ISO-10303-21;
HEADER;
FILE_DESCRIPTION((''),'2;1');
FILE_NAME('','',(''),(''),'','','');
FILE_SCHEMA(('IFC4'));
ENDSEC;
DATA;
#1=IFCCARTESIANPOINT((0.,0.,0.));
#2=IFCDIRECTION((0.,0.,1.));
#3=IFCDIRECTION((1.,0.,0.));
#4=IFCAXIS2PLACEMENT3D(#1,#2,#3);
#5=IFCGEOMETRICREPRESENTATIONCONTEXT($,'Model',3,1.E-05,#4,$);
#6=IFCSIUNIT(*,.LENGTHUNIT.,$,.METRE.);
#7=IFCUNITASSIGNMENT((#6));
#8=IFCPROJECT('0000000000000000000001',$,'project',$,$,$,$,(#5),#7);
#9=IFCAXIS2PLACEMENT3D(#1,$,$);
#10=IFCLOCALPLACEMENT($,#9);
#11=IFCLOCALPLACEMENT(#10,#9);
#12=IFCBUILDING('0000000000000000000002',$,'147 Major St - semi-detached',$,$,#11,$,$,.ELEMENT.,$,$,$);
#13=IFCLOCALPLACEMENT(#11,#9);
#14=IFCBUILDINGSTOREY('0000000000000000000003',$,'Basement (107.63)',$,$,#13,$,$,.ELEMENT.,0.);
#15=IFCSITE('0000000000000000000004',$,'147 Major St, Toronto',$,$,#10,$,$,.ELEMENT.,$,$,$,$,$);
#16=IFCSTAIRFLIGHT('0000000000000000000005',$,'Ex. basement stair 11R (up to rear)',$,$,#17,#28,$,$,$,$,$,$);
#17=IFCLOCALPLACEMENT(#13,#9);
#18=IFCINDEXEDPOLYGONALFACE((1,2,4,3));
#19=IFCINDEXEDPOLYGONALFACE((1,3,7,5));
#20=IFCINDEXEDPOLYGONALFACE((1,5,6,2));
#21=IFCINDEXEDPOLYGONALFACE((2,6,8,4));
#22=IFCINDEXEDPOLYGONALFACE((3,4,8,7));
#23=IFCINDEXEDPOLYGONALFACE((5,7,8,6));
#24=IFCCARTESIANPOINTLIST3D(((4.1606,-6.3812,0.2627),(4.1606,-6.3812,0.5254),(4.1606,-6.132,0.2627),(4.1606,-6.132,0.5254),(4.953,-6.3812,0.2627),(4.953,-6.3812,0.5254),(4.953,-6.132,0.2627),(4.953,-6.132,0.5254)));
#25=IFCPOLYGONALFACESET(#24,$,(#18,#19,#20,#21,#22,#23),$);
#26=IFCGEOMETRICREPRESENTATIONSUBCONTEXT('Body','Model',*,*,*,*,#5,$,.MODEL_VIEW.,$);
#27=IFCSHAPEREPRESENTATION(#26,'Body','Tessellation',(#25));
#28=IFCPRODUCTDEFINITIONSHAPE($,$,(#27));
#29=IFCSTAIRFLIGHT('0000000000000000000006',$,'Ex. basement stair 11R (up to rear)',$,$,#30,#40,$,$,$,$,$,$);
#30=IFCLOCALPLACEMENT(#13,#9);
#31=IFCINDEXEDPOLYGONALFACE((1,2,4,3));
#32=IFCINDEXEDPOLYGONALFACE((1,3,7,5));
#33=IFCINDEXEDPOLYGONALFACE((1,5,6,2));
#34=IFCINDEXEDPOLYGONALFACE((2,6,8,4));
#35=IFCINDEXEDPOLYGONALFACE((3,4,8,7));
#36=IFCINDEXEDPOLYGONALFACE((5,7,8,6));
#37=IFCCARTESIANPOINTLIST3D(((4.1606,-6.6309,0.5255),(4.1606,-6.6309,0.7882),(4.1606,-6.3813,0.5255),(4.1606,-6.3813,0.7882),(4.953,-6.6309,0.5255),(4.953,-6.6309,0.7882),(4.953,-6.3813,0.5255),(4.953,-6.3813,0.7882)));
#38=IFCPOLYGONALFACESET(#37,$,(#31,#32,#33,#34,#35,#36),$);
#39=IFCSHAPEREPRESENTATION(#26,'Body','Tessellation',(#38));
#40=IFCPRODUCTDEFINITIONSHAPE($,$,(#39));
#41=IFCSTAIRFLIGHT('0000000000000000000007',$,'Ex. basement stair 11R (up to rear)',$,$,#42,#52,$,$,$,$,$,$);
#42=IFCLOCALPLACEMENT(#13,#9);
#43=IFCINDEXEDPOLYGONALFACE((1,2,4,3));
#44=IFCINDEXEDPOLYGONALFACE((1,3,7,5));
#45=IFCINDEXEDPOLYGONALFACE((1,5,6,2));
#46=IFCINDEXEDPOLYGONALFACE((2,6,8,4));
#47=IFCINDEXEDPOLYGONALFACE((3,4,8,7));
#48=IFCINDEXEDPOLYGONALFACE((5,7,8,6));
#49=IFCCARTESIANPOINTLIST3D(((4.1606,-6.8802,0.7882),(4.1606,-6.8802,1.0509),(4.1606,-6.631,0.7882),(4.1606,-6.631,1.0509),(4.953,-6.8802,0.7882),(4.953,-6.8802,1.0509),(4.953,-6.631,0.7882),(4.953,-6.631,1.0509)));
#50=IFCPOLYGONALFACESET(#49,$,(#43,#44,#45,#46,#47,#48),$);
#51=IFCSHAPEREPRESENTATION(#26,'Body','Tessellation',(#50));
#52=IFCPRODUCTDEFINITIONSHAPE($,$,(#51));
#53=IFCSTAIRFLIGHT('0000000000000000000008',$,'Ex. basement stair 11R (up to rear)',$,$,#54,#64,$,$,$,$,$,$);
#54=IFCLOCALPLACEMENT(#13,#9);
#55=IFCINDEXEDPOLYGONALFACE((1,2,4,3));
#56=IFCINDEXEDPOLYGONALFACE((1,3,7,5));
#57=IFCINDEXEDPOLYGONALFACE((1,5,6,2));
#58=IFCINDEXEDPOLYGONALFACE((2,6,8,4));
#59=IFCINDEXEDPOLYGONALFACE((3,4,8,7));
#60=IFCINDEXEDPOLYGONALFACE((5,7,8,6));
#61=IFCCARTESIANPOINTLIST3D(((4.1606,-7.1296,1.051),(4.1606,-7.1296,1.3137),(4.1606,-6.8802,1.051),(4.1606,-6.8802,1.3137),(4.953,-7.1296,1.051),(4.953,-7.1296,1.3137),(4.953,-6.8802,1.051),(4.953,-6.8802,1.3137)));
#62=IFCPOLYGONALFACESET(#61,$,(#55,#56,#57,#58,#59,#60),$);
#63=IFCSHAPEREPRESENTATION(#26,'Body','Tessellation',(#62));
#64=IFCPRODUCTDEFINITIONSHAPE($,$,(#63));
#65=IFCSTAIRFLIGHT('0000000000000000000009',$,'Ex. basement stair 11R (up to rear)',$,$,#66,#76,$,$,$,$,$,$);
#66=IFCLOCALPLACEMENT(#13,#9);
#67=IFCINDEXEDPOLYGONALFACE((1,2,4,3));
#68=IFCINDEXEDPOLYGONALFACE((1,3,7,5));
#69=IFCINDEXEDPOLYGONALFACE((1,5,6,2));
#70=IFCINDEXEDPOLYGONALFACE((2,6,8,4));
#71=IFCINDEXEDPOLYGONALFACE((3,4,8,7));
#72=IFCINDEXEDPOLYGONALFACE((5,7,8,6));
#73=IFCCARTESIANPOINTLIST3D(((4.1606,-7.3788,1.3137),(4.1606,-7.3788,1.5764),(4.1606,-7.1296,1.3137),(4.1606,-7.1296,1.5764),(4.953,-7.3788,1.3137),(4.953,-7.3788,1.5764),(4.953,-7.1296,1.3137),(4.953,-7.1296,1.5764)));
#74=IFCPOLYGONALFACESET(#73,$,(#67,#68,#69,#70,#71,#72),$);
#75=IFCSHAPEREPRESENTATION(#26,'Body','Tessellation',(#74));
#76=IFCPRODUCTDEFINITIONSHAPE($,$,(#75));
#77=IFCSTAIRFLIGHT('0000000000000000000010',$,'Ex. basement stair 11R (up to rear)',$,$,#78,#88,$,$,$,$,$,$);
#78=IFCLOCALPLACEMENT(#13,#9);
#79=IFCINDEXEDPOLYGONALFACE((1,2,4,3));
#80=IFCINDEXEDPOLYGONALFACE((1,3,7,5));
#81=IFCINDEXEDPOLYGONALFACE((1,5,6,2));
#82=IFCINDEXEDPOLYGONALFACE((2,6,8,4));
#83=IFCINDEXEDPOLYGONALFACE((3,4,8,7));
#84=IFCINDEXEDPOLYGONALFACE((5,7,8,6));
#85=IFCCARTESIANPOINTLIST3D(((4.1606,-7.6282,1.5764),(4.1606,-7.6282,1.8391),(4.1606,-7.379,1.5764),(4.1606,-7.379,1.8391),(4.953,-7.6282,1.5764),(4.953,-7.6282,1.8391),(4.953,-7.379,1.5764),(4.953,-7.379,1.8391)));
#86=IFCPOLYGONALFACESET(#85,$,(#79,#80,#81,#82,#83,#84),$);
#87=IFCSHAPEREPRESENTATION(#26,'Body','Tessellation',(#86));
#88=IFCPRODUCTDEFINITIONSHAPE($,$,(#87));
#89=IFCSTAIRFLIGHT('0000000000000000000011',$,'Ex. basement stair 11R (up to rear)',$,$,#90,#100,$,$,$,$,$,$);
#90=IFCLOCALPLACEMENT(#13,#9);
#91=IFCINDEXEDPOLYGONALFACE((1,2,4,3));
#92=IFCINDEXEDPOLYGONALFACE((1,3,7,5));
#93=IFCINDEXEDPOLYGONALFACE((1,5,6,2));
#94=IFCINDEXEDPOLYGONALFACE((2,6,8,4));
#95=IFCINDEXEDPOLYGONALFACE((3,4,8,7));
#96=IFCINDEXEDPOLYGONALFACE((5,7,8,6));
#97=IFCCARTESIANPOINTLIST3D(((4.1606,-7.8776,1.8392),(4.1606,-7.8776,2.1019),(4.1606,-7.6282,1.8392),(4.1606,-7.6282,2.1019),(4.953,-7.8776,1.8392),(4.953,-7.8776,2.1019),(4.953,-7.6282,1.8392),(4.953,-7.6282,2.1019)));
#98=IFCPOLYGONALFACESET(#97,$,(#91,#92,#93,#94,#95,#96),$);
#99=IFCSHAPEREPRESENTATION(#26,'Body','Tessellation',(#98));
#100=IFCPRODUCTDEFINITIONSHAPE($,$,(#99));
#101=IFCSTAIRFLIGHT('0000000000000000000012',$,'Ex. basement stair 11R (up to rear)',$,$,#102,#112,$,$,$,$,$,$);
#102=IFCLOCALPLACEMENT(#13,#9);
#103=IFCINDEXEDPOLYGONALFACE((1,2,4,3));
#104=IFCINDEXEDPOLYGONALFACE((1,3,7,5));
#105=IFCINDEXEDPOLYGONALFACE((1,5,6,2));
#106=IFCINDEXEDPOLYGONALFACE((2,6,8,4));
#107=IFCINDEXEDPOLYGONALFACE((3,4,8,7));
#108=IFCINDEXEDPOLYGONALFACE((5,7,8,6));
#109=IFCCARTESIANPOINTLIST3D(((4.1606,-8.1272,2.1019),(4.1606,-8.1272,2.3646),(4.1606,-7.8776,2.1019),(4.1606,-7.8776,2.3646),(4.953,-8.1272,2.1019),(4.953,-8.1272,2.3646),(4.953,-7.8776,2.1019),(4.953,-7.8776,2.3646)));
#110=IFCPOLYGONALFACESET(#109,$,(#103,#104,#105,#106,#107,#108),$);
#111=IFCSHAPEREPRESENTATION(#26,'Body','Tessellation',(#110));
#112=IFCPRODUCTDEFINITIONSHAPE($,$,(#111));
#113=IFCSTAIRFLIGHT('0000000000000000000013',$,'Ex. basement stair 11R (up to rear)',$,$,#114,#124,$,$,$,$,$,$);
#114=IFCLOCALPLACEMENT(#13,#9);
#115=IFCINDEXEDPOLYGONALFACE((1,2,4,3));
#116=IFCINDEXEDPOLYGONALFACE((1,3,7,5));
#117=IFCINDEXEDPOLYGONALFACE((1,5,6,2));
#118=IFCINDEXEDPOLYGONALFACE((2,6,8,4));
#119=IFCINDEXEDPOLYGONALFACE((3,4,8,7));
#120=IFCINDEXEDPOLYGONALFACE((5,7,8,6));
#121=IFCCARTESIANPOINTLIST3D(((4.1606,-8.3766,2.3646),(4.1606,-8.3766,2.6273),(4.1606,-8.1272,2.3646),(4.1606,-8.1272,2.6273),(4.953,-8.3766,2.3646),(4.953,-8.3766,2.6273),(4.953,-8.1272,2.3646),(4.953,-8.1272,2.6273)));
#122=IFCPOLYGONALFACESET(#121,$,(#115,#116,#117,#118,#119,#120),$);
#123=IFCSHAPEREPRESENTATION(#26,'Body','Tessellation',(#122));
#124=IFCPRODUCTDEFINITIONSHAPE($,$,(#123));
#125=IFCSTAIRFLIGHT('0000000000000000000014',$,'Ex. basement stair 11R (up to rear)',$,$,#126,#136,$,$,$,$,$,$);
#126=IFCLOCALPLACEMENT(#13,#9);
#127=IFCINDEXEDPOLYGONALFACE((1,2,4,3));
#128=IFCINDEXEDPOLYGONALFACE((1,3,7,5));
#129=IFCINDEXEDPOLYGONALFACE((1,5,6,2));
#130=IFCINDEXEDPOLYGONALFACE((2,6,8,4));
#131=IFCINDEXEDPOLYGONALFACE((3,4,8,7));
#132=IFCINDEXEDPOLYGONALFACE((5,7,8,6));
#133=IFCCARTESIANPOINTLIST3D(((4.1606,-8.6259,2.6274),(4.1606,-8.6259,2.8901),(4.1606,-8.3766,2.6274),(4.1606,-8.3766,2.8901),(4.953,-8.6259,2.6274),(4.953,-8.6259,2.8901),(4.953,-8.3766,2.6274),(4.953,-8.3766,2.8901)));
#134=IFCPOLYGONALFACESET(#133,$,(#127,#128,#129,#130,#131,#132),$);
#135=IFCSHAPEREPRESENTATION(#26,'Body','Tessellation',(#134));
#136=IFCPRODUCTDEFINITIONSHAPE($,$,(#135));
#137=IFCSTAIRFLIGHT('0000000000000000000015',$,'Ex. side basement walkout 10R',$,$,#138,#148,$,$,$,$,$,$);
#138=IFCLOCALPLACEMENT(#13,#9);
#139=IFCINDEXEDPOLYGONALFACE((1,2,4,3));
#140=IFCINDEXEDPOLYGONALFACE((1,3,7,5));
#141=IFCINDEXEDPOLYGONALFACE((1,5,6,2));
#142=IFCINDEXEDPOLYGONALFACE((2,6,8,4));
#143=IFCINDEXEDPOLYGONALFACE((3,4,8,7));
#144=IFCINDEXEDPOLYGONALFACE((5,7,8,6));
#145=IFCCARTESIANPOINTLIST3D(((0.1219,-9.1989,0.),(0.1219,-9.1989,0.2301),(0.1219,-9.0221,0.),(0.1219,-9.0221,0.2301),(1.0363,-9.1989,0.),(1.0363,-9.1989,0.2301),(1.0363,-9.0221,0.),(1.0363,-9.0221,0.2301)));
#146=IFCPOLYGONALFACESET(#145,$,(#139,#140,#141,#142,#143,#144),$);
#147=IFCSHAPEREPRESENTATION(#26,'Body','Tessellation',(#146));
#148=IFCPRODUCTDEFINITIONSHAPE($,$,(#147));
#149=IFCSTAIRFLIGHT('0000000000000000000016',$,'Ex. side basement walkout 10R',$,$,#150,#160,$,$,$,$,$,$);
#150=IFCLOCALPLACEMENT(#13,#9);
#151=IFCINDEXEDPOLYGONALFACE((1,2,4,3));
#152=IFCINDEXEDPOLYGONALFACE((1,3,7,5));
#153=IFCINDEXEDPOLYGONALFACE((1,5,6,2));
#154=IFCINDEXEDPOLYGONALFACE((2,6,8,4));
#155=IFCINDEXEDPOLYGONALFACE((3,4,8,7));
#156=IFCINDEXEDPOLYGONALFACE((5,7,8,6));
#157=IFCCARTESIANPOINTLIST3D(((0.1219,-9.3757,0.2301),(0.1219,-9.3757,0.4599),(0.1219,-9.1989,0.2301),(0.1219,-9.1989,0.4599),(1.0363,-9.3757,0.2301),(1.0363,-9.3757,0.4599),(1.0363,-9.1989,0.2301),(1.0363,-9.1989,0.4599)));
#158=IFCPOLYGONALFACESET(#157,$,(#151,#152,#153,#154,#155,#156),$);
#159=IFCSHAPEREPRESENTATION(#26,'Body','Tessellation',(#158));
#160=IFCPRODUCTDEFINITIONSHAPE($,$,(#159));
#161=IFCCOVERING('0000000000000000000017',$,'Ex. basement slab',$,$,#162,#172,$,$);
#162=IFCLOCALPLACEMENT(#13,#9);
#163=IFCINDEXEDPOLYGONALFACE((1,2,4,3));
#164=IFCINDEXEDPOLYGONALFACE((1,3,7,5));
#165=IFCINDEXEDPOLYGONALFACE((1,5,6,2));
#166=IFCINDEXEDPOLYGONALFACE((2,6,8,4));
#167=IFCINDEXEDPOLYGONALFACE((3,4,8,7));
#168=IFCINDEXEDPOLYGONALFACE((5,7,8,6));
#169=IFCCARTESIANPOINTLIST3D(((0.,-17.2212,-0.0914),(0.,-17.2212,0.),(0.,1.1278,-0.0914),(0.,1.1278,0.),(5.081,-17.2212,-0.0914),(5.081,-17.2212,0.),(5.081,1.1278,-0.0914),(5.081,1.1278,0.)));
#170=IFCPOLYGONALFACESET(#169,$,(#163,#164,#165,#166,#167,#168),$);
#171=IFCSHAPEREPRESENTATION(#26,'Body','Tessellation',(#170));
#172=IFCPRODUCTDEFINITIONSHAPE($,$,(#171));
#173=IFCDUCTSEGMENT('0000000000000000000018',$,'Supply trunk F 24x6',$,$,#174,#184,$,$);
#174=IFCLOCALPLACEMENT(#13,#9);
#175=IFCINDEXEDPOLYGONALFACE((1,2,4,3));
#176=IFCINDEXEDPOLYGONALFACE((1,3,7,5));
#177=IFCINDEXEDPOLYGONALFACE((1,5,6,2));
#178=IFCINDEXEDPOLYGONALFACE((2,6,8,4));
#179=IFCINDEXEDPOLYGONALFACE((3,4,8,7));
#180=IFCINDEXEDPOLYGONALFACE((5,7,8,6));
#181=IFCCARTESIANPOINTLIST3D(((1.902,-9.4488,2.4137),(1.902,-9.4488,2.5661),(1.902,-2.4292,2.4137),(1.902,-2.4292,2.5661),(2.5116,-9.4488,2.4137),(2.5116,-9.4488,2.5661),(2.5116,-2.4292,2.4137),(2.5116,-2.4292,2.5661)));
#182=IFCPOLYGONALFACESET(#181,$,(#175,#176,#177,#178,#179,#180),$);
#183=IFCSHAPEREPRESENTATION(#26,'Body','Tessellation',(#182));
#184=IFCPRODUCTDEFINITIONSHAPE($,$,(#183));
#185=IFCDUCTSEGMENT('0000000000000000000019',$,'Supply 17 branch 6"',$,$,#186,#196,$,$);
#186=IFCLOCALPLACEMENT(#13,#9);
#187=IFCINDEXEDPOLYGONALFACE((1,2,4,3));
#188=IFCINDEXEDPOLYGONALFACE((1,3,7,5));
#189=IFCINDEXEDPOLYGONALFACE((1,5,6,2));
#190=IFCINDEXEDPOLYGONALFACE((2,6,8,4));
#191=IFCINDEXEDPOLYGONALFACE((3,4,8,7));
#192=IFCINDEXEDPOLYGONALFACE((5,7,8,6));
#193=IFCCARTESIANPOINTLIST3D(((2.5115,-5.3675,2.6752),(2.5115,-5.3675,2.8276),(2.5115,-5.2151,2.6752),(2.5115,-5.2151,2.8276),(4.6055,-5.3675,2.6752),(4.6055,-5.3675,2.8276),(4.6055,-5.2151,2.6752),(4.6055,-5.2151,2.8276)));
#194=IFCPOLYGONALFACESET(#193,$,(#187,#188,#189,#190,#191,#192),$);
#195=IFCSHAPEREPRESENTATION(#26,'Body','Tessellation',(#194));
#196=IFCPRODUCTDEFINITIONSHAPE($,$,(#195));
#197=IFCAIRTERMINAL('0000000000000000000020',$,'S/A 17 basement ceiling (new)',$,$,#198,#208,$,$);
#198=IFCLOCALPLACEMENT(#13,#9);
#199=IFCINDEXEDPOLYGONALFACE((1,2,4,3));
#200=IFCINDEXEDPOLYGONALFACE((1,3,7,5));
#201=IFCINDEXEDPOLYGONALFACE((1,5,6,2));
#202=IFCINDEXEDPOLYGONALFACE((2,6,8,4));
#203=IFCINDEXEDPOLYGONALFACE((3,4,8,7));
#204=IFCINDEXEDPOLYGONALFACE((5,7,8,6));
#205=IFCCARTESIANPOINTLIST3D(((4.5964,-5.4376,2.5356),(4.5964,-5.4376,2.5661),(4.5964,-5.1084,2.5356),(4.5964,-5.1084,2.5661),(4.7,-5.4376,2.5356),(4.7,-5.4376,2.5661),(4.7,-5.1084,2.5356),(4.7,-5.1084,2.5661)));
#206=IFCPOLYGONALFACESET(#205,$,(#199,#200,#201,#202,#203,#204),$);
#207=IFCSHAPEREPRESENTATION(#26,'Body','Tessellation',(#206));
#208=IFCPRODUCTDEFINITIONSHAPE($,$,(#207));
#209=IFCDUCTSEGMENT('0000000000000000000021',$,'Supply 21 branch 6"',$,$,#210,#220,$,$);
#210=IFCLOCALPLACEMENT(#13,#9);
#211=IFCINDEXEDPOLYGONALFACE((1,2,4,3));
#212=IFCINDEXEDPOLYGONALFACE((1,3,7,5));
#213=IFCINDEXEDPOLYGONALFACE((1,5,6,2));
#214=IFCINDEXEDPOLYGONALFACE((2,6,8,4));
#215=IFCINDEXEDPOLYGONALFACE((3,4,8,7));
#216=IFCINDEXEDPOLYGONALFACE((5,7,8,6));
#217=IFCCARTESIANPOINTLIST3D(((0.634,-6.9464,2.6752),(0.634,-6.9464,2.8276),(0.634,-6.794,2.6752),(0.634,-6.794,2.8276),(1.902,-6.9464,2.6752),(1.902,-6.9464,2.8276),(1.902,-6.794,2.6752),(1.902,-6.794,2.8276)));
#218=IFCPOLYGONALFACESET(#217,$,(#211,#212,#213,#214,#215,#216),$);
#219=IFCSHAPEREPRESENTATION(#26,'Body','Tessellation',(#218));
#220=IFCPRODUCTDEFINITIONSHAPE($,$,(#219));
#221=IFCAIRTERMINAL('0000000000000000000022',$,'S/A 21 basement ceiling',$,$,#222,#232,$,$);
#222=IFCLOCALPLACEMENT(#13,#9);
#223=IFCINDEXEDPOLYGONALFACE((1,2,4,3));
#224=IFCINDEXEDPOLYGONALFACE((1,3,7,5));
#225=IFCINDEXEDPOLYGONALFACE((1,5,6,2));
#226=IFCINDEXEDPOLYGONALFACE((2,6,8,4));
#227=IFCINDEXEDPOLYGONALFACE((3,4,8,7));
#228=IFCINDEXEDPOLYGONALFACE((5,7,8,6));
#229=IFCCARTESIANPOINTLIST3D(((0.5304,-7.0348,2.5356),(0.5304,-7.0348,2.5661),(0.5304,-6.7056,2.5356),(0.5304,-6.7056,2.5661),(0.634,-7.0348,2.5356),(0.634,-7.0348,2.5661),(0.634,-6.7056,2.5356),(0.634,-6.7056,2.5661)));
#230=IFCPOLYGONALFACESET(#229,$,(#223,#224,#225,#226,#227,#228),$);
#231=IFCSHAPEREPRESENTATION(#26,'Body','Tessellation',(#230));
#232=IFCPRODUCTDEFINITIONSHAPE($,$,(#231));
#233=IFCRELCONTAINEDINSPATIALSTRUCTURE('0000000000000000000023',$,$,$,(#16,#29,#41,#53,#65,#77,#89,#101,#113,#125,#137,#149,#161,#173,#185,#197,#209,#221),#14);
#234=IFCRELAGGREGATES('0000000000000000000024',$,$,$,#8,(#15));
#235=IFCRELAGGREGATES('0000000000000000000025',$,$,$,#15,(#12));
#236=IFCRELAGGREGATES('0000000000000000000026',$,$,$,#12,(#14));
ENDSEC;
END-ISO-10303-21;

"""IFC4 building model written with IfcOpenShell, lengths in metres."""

from ifc_helpers import new_model, si_unit, frame, origin, origin_with_axes, place, context, subcontext, project, spatial, rectangle, extrude, element, save


model = new_model("IFC4")

# Units and contexts
model_context = context("Model", 3, precision=1e-05, world=origin_with_axes())
body_context = subcontext(model_context, "Body", "Model", "MODEL_VIEW")
ifc_project = project(units=[si_unit("LENGTHUNIT", "METRE")], contexts=[model_context])

# Site, building, storey
site_placement = place(None, origin())
site = spatial("IfcSite", under=ifc_project, at=site_placement, Name="147 Major St, Toronto", CompositionType="ELEMENT")
building_placement = place(site_placement, origin())
building = spatial("IfcBuilding", under=site, at=building_placement, Name="147 Major St - semi-detached", CompositionType="ELEMENT")
storey_placement = place(building_placement, origin())
storey = spatial("IfcBuildingStorey", under=building, at=storey_placement, Name="Basement (107.63)", CompositionType="ELEMENT", Elevation=0.0)

# Stair flights
for number, where, name in (
    (1, (4.5568, -6.2566, 0.2627), "Ex. basement stair 11R (up to rear)"),
):
    element("IfcStairFlight", number, at=place(storey_placement, frame(where)), inside=storey, Name=name, context=body_context, shape_type="SweptSolid", body=[
        extrude(rectangle(XDim=0.7925, YDim=0.2493), origin_with_axes(), (0.0, 0.0, 1.0), 0.2627),
    ])
stair_flight_1_placement = place(storey_placement, frame((4.5568, -6.5061, 0.5255)))
element("IfcStairFlight", 2, at=stair_flight_1_placement, inside=storey, Name="Ex. basement stair 11R (up to rear)", context=body_context, shape_type="SweptSolid", body=[
    extrude(rectangle(XDim=0.7925, YDim=0.2496), origin_with_axes(), (0.0, 0.0, 1.0), 0.2627),
])
for number, where, name in (
    (3, (4.5568, -6.7556, 0.7882), "Ex. basement stair 11R (up to rear)"),
    (4, (4.5568, -7.0049, 1.051), "Ex. basement stair 11R (up to rear)"),
    (5, (4.5568, -7.2542, 1.3137), "Ex. basement stair 11R (up to rear)"),
    (6, (4.5568, -7.5036, 1.5764), "Ex. basement stair 11R (up to rear)"),
    (7, (4.5568, -7.7529, 1.8392), "Ex. basement stair 11R (up to rear)"),
):
    element("IfcStairFlight", number, at=place(storey_placement, frame(where)), inside=storey, Name=name, context=body_context, shape_type="SweptSolid", body=[
        extrude(rectangle(XDim=0.7925, YDim=0.2493), origin_with_axes(), (0.0, 0.0, 1.0), 0.2627),
    ])
stair_flight_2_placement = place(storey_placement, frame((4.5568, -8.0024, 2.1019)))
element("IfcStairFlight", 8, at=stair_flight_2_placement, inside=storey, Name="Ex. basement stair 11R (up to rear)", context=body_context, shape_type="SweptSolid", body=[
    extrude(rectangle(XDim=0.7925, YDim=0.2496), origin_with_axes(), (0.0, 0.0, 1.0), 0.2627),
])
for number, where, name in (
    (9, (4.5568, -8.2519, 2.3646), "Ex. basement stair 11R (up to rear)"),
    (10, (4.5568, -8.5012, 2.6274), "Ex. basement stair 11R (up to rear)"),
):
    element("IfcStairFlight", number, at=place(storey_placement, frame(where)), inside=storey, Name=name, context=body_context, shape_type="SweptSolid", body=[
        extrude(rectangle(XDim=0.7925, YDim=0.2493), origin_with_axes(), (0.0, 0.0, 1.0), 0.2627),
    ])
stair_flight_3_placement = place(storey_placement, frame((0.5791, -9.1105, 0.0)))
element("IfcStairFlight", 11, at=stair_flight_3_placement, inside=storey, Name="Ex. side basement walkout 10R", context=body_context, shape_type="SweptSolid", body=[
    extrude(rectangle(XDim=0.9144, YDim=0.1768), origin_with_axes(), (0.0, 0.0, 1.0), 0.2301),
])
stair_flight_4_placement = place(storey_placement, frame((0.5791, -9.2873, 0.2301)))
element("IfcStairFlight", 12, at=stair_flight_4_placement, inside=storey, Name="Ex. side basement walkout 10R", context=body_context, shape_type="SweptSolid", body=[
    extrude(rectangle(XDim=0.9144, YDim=0.1768), origin_with_axes(), (0.0, 0.0, 1.0), 0.2298),
])

# Covering
covering_placement = place(storey_placement, frame((2.5405, -8.0467, -0.0914)))
element("IfcCovering", 13, at=covering_placement, inside=storey, Name="Ex. basement slab", context=body_context, shape_type="SweptSolid", body=[
    extrude(rectangle(XDim=5.081, YDim=18.349), origin_with_axes(), (0.0, 0.0, 1.0), 0.0914),
])

# Duct segments
duct_segment_1_placement = place(storey_placement, frame((2.2068, -5.939, 2.4137)))
element("IfcDuctSegment", 14, at=duct_segment_1_placement, inside=storey, Name="Supply trunk F 24x6", context=body_context, shape_type="SweptSolid", body=[
    extrude(rectangle(XDim=0.6096, YDim=7.0195), origin_with_axes(), (0.0, 0.0, 1.0), 0.1524),
])
duct_segment_2_placement = place(storey_placement, frame((3.5585, -5.2913, 2.6752)))
element("IfcDuctSegment", 15, at=duct_segment_2_placement, inside=storey, Name="Supply 17 branch 6\"", context=body_context, shape_type="SweptSolid", body=[
    extrude(rectangle(XDim=2.094, YDim=0.1524), origin_with_axes(), (0.0, 0.0, 1.0), 0.1524),
])

# Air terminal
air_terminal_1_placement = place(storey_placement, frame((4.6482, -5.273, 2.5356)))
element("IfcAirTerminal", 16, at=air_terminal_1_placement, inside=storey, Name="S/A 17 basement ceiling (new)", context=body_context, shape_type="SweptSolid", body=[
    extrude(rectangle(XDim=0.1036, YDim=0.3292), origin_with_axes(), (0.0, 0.0, 1.0), 0.0305),
])

# Duct segment
duct_segment_3_placement = place(storey_placement, frame((1.268, -6.8702, 2.6752)))
element("IfcDuctSegment", 17, at=duct_segment_3_placement, inside=storey, Name="Supply 21 branch 6\"", context=body_context, shape_type="SweptSolid", body=[
    extrude(rectangle(XDim=1.268, YDim=0.1524), origin_with_axes(), (0.0, 0.0, 1.0), 0.1524),
])

# Air terminal
air_terminal_2_placement = place(storey_placement, frame((0.5822, -6.8702, 2.5356)))
element("IfcAirTerminal", 18, at=air_terminal_2_placement, inside=storey, Name="S/A 21 basement ceiling", context=body_context, shape_type="SweptSolid", body=[
    extrude(rectangle(XDim=0.1036, YDim=0.3292), origin_with_axes(), (0.0, 0.0, 1.0), 0.0305),
])

save(model, "model.ifc")
